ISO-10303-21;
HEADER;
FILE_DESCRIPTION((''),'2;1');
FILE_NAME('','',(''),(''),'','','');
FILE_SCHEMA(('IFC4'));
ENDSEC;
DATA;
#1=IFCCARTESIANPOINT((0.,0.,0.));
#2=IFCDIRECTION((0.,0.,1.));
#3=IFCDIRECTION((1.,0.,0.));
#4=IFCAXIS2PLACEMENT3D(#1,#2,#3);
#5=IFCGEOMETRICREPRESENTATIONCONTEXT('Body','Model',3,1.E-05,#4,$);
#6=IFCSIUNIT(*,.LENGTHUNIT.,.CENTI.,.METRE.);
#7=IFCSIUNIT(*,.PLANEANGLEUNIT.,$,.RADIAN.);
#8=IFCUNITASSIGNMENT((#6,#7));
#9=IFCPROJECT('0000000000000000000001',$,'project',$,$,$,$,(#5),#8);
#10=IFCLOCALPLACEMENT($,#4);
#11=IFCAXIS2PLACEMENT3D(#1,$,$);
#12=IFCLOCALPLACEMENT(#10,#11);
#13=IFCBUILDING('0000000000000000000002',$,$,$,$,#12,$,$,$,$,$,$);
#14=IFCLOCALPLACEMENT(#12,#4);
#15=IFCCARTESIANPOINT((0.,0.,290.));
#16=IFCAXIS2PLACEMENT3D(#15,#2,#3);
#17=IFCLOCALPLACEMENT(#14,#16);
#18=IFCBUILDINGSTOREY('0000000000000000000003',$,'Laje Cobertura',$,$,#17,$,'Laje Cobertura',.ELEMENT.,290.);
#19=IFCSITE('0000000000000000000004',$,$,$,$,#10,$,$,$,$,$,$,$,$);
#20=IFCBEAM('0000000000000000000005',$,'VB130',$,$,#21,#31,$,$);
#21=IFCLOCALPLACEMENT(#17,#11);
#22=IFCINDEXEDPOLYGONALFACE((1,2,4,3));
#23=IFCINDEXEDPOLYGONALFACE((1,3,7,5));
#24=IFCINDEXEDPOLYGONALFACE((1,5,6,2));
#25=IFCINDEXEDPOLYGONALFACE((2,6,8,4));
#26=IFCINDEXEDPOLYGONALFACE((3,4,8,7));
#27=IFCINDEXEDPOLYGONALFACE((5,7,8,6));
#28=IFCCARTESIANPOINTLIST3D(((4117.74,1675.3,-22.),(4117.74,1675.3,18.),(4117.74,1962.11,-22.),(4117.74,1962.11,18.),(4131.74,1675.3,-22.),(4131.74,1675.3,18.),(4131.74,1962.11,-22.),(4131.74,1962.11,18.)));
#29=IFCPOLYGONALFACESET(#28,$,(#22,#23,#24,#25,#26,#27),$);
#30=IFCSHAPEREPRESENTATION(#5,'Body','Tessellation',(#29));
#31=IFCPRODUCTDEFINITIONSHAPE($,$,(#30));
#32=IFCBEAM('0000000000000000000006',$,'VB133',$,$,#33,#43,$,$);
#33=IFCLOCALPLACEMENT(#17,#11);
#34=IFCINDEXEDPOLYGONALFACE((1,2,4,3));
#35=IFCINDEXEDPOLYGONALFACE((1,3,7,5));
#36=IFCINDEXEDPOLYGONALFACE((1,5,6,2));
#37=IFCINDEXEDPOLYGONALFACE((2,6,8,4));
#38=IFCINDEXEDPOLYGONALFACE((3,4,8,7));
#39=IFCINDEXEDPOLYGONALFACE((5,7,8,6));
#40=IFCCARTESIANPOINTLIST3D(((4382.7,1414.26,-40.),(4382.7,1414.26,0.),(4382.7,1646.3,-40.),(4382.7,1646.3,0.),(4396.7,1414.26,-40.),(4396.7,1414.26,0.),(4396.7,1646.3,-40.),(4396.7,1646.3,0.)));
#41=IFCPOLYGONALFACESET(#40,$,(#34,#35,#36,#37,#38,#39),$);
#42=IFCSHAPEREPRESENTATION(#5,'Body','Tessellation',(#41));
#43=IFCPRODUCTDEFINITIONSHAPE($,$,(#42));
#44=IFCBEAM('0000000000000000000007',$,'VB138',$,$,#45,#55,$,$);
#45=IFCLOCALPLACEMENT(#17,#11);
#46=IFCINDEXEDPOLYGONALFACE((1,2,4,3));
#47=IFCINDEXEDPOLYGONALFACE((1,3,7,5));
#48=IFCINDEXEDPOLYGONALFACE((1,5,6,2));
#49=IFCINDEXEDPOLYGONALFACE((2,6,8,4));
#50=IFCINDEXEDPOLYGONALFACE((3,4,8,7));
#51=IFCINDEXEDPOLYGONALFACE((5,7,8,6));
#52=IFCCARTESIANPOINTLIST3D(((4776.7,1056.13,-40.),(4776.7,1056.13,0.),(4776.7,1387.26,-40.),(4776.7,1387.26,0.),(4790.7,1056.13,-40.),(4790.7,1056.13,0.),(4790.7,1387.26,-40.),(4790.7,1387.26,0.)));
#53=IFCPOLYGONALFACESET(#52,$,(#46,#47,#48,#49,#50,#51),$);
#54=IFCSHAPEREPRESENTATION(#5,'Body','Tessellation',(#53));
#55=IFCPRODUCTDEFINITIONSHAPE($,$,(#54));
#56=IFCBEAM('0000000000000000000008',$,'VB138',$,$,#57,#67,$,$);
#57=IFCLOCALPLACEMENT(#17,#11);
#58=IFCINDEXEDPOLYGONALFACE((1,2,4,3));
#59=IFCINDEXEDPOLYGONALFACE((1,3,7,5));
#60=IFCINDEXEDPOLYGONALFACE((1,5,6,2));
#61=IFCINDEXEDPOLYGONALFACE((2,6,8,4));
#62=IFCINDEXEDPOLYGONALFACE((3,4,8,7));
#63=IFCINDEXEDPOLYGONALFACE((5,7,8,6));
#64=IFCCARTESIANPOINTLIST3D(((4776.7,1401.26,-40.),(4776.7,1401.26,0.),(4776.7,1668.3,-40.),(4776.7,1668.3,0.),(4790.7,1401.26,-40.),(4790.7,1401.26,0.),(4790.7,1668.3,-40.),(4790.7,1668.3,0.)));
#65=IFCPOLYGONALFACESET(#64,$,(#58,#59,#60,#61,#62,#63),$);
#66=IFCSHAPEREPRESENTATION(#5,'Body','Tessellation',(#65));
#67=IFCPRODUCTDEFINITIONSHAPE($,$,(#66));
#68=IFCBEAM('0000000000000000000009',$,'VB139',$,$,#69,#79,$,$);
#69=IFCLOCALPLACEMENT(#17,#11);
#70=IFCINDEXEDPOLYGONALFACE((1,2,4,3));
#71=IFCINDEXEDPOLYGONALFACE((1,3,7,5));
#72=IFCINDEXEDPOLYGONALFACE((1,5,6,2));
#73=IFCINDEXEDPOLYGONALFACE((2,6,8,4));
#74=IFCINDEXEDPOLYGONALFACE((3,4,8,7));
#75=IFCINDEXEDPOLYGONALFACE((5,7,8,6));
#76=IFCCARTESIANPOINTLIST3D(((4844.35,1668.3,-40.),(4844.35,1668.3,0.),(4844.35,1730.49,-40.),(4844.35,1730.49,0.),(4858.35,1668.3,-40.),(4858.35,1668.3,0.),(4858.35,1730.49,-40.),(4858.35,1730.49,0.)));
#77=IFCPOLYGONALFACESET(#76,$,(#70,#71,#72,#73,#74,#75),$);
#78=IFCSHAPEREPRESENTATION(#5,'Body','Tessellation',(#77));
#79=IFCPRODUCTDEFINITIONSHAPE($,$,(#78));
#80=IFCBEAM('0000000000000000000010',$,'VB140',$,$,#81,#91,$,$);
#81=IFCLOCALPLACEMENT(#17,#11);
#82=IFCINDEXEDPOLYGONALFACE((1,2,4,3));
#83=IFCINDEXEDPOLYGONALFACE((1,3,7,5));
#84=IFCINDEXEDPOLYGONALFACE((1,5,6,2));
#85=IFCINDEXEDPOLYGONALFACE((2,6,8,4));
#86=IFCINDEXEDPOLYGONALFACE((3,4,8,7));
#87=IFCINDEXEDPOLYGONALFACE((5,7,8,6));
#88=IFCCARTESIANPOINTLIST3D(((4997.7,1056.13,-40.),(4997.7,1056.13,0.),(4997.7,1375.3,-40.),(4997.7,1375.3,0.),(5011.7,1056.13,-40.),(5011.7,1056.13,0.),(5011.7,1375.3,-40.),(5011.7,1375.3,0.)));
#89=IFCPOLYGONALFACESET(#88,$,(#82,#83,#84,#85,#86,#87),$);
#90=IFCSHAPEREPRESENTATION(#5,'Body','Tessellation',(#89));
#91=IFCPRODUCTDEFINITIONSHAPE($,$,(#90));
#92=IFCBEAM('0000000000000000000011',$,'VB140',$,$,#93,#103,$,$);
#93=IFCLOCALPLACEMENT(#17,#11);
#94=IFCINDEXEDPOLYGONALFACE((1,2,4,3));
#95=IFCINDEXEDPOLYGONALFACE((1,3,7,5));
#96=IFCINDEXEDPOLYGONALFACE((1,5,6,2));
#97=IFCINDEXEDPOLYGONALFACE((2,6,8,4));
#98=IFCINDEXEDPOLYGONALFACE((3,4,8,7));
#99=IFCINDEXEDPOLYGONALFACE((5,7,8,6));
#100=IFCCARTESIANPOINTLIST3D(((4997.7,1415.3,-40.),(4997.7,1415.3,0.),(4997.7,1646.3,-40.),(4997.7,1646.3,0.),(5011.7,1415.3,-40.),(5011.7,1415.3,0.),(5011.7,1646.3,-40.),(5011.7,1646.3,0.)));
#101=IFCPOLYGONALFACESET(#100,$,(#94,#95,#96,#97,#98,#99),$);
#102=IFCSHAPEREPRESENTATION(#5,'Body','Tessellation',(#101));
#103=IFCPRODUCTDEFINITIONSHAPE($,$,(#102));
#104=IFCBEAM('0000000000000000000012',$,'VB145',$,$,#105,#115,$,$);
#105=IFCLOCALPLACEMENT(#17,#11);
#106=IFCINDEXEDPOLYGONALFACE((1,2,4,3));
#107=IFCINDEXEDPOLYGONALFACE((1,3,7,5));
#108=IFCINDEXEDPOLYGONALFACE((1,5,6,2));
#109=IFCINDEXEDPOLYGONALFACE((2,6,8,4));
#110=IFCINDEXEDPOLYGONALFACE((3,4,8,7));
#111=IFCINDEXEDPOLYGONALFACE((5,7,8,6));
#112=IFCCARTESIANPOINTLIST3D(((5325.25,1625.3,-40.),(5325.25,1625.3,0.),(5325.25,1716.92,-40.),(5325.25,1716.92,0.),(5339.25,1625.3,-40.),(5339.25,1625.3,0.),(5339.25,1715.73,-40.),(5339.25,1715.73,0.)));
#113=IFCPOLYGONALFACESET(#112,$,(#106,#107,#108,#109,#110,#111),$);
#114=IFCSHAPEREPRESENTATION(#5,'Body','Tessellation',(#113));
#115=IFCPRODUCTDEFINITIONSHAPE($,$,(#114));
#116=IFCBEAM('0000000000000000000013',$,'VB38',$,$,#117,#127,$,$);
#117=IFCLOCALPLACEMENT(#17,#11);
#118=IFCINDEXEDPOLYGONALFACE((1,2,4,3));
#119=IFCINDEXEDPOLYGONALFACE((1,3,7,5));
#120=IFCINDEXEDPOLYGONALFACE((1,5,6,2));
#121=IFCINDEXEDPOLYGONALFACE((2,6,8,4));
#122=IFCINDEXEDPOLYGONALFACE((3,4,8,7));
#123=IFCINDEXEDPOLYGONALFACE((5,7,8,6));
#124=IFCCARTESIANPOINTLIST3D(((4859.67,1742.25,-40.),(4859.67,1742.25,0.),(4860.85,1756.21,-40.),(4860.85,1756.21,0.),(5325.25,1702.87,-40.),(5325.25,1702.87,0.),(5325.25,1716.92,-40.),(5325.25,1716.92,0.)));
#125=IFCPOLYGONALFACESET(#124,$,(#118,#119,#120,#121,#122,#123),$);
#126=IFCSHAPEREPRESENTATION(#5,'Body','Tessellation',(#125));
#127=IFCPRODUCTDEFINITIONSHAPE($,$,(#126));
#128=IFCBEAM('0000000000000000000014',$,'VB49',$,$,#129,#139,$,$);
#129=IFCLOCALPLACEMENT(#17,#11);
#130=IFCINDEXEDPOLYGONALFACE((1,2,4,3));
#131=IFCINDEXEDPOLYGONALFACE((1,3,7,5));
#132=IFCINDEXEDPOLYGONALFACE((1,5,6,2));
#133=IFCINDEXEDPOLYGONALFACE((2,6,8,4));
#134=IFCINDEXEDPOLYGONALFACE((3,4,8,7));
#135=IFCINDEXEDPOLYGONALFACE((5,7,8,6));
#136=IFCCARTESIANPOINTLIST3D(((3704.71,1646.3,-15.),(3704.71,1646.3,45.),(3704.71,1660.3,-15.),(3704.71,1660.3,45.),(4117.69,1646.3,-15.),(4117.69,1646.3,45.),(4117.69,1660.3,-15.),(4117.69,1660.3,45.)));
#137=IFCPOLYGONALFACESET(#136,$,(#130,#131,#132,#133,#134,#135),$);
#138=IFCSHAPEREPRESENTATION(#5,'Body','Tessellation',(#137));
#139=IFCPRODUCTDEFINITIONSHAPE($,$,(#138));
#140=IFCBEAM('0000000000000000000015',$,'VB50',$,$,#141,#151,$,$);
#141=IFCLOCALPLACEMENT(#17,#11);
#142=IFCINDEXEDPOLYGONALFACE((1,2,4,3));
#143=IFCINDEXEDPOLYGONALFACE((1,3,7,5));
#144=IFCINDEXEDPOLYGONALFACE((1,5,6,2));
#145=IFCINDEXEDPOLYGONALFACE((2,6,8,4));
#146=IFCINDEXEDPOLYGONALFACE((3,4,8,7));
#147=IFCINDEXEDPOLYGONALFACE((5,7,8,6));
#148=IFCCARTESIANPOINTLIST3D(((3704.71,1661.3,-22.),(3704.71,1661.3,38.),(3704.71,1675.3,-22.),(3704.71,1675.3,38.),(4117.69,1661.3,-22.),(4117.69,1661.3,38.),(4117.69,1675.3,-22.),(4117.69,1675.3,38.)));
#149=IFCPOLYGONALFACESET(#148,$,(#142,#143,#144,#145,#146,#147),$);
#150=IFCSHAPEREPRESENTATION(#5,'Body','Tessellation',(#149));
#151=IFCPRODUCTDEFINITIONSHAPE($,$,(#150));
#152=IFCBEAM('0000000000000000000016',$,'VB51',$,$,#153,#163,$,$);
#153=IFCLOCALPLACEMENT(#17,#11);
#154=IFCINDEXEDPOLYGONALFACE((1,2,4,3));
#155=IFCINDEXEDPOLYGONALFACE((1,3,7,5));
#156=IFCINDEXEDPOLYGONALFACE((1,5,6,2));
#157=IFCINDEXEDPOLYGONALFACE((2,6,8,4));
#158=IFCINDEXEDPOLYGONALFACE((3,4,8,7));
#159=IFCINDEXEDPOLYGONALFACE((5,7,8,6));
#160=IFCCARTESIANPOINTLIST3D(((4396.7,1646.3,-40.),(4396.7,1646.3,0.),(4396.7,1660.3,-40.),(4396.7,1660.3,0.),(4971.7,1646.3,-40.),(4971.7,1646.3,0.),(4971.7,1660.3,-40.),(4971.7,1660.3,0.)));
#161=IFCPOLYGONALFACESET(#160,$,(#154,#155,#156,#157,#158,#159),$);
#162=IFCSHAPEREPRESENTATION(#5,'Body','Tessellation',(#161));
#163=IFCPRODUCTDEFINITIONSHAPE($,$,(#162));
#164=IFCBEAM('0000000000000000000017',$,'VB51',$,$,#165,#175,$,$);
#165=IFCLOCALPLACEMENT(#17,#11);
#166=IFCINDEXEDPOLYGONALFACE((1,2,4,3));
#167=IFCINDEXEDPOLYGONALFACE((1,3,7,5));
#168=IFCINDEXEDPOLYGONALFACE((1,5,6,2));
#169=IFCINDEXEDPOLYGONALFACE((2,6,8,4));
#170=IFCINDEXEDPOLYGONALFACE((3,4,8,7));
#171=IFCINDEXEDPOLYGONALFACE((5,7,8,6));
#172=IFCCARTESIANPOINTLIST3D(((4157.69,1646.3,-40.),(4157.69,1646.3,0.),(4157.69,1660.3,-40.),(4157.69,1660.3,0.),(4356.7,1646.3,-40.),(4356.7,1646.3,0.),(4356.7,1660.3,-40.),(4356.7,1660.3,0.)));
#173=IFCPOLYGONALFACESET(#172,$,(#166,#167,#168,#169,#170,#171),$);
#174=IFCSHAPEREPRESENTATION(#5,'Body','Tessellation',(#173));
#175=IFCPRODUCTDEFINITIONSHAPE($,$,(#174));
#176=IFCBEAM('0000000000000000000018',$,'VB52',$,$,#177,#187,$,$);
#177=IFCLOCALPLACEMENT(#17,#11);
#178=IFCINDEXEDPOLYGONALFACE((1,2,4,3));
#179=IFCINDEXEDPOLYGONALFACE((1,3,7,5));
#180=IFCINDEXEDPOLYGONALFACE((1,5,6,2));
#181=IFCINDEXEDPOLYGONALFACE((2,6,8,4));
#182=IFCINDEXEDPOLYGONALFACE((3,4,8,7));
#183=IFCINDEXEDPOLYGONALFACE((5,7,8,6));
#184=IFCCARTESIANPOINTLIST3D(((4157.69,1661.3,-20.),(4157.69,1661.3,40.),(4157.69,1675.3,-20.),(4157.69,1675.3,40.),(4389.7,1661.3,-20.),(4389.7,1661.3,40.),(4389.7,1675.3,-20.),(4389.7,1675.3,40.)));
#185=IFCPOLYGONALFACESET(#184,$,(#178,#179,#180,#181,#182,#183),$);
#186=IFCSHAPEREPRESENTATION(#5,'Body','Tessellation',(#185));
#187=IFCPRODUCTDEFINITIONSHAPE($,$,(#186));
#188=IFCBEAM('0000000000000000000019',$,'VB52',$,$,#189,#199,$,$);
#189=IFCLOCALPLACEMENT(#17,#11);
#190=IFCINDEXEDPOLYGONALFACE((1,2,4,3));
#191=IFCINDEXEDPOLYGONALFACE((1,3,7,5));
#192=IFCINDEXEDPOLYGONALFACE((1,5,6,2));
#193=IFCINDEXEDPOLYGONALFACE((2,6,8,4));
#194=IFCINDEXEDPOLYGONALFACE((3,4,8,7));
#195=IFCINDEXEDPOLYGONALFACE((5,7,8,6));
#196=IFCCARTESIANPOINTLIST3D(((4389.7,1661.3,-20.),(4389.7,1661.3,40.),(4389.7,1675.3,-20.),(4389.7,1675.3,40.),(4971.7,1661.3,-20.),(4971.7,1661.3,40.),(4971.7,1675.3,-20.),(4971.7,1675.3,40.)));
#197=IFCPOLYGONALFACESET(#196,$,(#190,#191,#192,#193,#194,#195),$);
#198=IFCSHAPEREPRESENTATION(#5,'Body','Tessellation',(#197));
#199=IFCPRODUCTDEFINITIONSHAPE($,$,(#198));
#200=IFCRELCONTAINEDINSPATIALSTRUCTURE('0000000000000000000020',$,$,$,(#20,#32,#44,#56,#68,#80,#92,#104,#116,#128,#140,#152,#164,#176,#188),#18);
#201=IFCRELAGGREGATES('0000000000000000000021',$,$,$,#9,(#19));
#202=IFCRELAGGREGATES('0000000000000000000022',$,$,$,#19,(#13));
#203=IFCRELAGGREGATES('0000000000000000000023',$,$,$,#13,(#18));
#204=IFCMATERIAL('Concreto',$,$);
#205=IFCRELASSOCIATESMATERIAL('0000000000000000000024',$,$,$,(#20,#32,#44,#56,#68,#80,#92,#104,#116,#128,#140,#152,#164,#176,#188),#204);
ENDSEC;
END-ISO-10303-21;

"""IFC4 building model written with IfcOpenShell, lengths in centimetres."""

from ifc_helpers import new_model, si_unit, frame, origin, origin_with_axes, origin_2d_with_axis, place, context, project, spatial, rectangle, extrude, clip, halfspace, material, element, save


model = new_model("IFC4")

# Units and contexts
model_context = context("Model", 3, precision=1e-05, world=origin_with_axes(), identifier="Body")
ifc_project = project(units=[si_unit("LENGTHUNIT", "METRE", prefix="CENTI"), si_unit("PLANEANGLEUNIT", "RADIAN")], contexts=[model_context])

# Site, building, storey
site_placement = place(None, origin_with_axes())
site = spatial("IfcSite", under=ifc_project, at=site_placement)
building_placement = place(site_placement, origin())
building = spatial("IfcBuilding", under=site, at=building_placement)
placement = place(building_placement, origin_with_axes())
storey_placement = place(placement, frame((0.0, 0.0, 290.0), z_axis=(0.0, 0.0, 1.0), x_axis=(1.0, 0.0, 0.0)))
storey = spatial("IfcBuildingStorey", under=building, at=storey_placement, Name="Laje Cobertura", LongName="Laje Cobertura", CompositionType="ELEMENT", Elevation=290.0)

# Shared definitions
ifc_material = material(Name="Concreto")

# Beams
beam_1_placement = place(storey_placement, frame((4124.74, 1818.7, 18.0), z_axis=(0.0, 0.0, 1.0), x_axis=(1.0, 0.0, 0.0)))
element("IfcBeam", 1, at=beam_1_placement, inside=storey, material=ifc_material, Name="VB130", context=model_context, shape_type="SolidModel", body=[
    extrude(rectangle(XDim=14.0, YDim=40.0, at=origin_2d_with_axis()), frame((0.0, -143.41, -20.0), z_axis=(0.0, 1.0, 0.0), x_axis=(1.0, 0.0, 0.0)), (0.0, 0.0, 1.0), 286.81),
])
beam_2_placement = place(storey_placement, frame((4389.7, 1530.28, 0.0), z_axis=(0.0, 0.0, 1.0), x_axis=(1.0, 0.0, 0.0)))
element("IfcBeam", 2, at=beam_2_placement, inside=storey, material=ifc_material, Name="VB133", context=model_context, shape_type="SolidModel", body=[
    extrude(rectangle(XDim=14.0, YDim=40.0, at=origin_2d_with_axis()), frame((0.0, -116.02, -20.0), z_axis=(0.0, 1.0, 0.0), x_axis=(1.0, 0.0, 0.0)), (0.0, 0.0, 1.0), 232.04),
])
beam_3_placement = place(storey_placement, frame((4783.7, 1221.69, 0.0), z_axis=(0.0, 0.0, 1.0), x_axis=(1.0, 0.0, 0.0)))
element("IfcBeam", 3, at=beam_3_placement, inside=storey, material=ifc_material, Name="VB138", context=model_context, shape_type="SolidModel", body=[
    extrude(rectangle(XDim=14.0, YDim=40.0, at=origin_2d_with_axis()), frame((0.0, -165.56, -20.0), z_axis=(0.0, 1.0, 0.0), x_axis=(1.0, 0.0, 0.0)), (0.0, 0.0, 1.0), 331.13),
])
beam_4_placement = place(storey_placement, frame((4783.7, 1534.78, 0.0), z_axis=(0.0, 0.0, 1.0), x_axis=(1.0, 0.0, 0.0)))
element("IfcBeam", 4, at=beam_4_placement, inside=storey, material=ifc_material, Name="VB138", context=model_context, shape_type="SolidModel", body=[
    extrude(rectangle(XDim=14.0, YDim=40.0, at=origin_2d_with_axis()), frame((0.0, -133.52, -20.0), z_axis=(0.0, 1.0, 0.0), x_axis=(1.0, 0.0, 0.0)), (0.0, 0.0, 1.0), 267.04),
])
beam_5_placement = place(storey_placement, frame((4851.35, 1699.39, 0.0), z_axis=(0.0, 0.0, 1.0), x_axis=(1.0, 0.0, 0.0)))
element("IfcBeam", 5, at=beam_5_placement, inside=storey, material=ifc_material, Name="VB139", context=model_context, shape_type="SolidModel", body=[
    extrude(rectangle(XDim=14.0, YDim=40.0, at=origin_2d_with_axis()), frame((0.0, -31.09, -20.0), z_axis=(0.0, 1.0, 0.0), x_axis=(1.0, 0.0, 0.0)), (0.0, 0.0, 1.0), 62.19),
])
beam_6_placement = place(storey_placement, frame((5004.7, 1215.71, 0.0), z_axis=(0.0, 0.0, 1.0), x_axis=(1.0, 0.0, 0.0)))
element("IfcBeam", 6, at=beam_6_placement, inside=storey, material=ifc_material, Name="VB140", context=model_context, shape_type="SolidModel", body=[
    extrude(rectangle(XDim=14.0, YDim=40.0, at=origin_2d_with_axis()), frame((0.0, -159.59, -20.0), z_axis=(0.0, 1.0, 0.0), x_axis=(1.0, 0.0, 0.0)), (0.0, 0.0, 1.0), 319.17),
])
beam_7_placement = place(storey_placement, frame((5004.7, 1530.8, 0.0), z_axis=(0.0, 0.0, 1.0), x_axis=(1.0, 0.0, 0.0)))
element("IfcBeam", 7, at=beam_7_placement, inside=storey, material=ifc_material, Name="VB140", context=model_context, shape_type="SolidModel", body=[
    extrude(rectangle(XDim=14.0, YDim=40.0, at=origin_2d_with_axis()), frame((0.0, -115.5, -20.0), z_axis=(0.0, 1.0, 0.0), x_axis=(1.0, 0.0, 0.0)), (0.0, 0.0, 1.0), 231.0),
])
beam_8_placement = place(storey_placement, frame((5332.25, 1671.11, 0.0), z_axis=(0.0, 0.0, 1.0), x_axis=(1.0, 0.0, 0.0)))
element("IfcBeam", 8, at=beam_8_placement, inside=storey, material=ifc_material, Name="VB145", context=model_context, shape_type="Clipping", body=[
    clip(extrude(rectangle(XDim=14.0, YDim=40.0, at=origin_2d_with_axis()), frame((0.0, -45.81, -20.0), z_axis=(0.0, 1.0, 0.0), x_axis=(1.0, 0.0, 0.0)), (0.0, 0.0, 1.0), 91.62), halfspace(frame((-7.0, 45.81, -40.0), z_axis=(-0.084298, -0.996441, 0.0), x_axis=(0.0, 0.0, -0.084298)), True)),
])
beam_9_placement = place(storey_placement, frame((5092.46, 1729.54, 0.0), z_axis=(0.0, 0.0, 1.0), x_axis=(1.0, 0.0, 0.0)))
element("IfcBeam", 9, at=beam_9_placement, inside=storey, material=ifc_material, Name="VB38", context=model_context, shape_type="Clipping", body=[
    clip(extrude(rectangle(XDim=14.0, YDim=40.0, at=origin_2d_with_axis()), frame((-232.2, 19.69, -20.0), z_axis=(0.996441, -0.084298, 0.0), x_axis=(0.084298, 0.996441, 0.0)), (0.0, 0.0, 1.0), 467.24), halfspace(frame((232.79, -12.62, -40.0), z_axis=(-1.0, 0.0, 0.0), x_axis=(0.0, 0.0, 0.084298)), True)),
])
for number, where, z_axis, x_axis, name in (
    (10, (3911.2, 1653.3, 45.0), (0.0, 0.0, 1.0), (1.0, 0.0, 0.0), "VB49"),
    (11, (3911.2, 1668.3, 38.0), (0.0, 0.0, 1.0), (1.0, 0.0, 0.0), "VB50"),
):
    element("IfcBeam", number, at=place(storey_placement, frame(where, z_axis=z_axis, x_axis=x_axis)), inside=storey, material=ifc_material, Name=name, context=model_context, shape_type="SolidModel", body=[
        extrude(rectangle(XDim=14.0, YDim=60.0, at=origin_2d_with_axis()), frame((-206.49, 0.0, -30.0), z_axis=(1.0, 0.0, 0.0), x_axis=(0.0, 1.0, 0.0)), (0.0, 0.0, 1.0), 412.98),
    ])
beam_10_placement = place(storey_placement, frame((4684.2, 1653.3, 0.0), z_axis=(0.0, 0.0, 1.0), x_axis=(1.0, 0.0, 0.0)))
element("IfcBeam", 12, at=beam_10_placement, inside=storey, material=ifc_material, Name="VB51", context=model_context, shape_type="SolidModel", body=[
    extrude(rectangle(XDim=14.0, YDim=40.0, at=origin_2d_with_axis()), frame((-287.5, 0.0, -20.0), z_axis=(1.0, 0.0, 0.0), x_axis=(0.0, 1.0, 0.0)), (0.0, 0.0, 1.0), 575.0),
])
beam_11_placement = place(storey_placement, frame((4257.19, 1653.3, 0.0), z_axis=(0.0, 0.0, 1.0), x_axis=(1.0, 0.0, 0.0)))
element("IfcBeam", 13, at=beam_11_placement, inside=storey, material=ifc_material, Name="VB51", context=model_context, shape_type="SolidModel", body=[
    extrude(rectangle(XDim=14.0, YDim=40.0, at=origin_2d_with_axis()), frame((-99.5, 0.0, -20.0), z_axis=(1.0, 0.0, 0.0), x_axis=(0.0, 1.0, 0.0)), (0.0, 0.0, 1.0), 199.01),
])
beam_12_placement = place(storey_placement, frame((4273.69, 1668.3, 40.0), z_axis=(0.0, 0.0, 1.0), x_axis=(1.0, 0.0, 0.0)))
element("IfcBeam", 14, at=beam_12_placement, inside=storey, material=ifc_material, Name="VB52", context=model_context, shape_type="SolidModel", body=[
    extrude(rectangle(XDim=14.0, YDim=60.0, at=origin_2d_with_axis()), frame((-116.0, 0.0, -30.0), z_axis=(1.0, 0.0, 0.0), x_axis=(0.0, 1.0, 0.0)), (0.0, 0.0, 1.0), 232.01),
])
beam_13_placement = place(storey_placement, frame((4680.7, 1668.3, 40.0), z_axis=(0.0, 0.0, 1.0), x_axis=(1.0, 0.0, 0.0)))
element("IfcBeam", 15, at=beam_13_placement, inside=storey, material=ifc_material, Name="VB52", context=model_context, shape_type="SolidModel", body=[
    extrude(rectangle(XDim=14.0, YDim=60.0, at=origin_2d_with_axis()), frame((-291.0, 0.0, -30.0), z_axis=(1.0, 0.0, 0.0), x_axis=(0.0, 1.0, 0.0)), (0.0, 0.0, 1.0), 582.0),
])

save(model, "model.ifc")
